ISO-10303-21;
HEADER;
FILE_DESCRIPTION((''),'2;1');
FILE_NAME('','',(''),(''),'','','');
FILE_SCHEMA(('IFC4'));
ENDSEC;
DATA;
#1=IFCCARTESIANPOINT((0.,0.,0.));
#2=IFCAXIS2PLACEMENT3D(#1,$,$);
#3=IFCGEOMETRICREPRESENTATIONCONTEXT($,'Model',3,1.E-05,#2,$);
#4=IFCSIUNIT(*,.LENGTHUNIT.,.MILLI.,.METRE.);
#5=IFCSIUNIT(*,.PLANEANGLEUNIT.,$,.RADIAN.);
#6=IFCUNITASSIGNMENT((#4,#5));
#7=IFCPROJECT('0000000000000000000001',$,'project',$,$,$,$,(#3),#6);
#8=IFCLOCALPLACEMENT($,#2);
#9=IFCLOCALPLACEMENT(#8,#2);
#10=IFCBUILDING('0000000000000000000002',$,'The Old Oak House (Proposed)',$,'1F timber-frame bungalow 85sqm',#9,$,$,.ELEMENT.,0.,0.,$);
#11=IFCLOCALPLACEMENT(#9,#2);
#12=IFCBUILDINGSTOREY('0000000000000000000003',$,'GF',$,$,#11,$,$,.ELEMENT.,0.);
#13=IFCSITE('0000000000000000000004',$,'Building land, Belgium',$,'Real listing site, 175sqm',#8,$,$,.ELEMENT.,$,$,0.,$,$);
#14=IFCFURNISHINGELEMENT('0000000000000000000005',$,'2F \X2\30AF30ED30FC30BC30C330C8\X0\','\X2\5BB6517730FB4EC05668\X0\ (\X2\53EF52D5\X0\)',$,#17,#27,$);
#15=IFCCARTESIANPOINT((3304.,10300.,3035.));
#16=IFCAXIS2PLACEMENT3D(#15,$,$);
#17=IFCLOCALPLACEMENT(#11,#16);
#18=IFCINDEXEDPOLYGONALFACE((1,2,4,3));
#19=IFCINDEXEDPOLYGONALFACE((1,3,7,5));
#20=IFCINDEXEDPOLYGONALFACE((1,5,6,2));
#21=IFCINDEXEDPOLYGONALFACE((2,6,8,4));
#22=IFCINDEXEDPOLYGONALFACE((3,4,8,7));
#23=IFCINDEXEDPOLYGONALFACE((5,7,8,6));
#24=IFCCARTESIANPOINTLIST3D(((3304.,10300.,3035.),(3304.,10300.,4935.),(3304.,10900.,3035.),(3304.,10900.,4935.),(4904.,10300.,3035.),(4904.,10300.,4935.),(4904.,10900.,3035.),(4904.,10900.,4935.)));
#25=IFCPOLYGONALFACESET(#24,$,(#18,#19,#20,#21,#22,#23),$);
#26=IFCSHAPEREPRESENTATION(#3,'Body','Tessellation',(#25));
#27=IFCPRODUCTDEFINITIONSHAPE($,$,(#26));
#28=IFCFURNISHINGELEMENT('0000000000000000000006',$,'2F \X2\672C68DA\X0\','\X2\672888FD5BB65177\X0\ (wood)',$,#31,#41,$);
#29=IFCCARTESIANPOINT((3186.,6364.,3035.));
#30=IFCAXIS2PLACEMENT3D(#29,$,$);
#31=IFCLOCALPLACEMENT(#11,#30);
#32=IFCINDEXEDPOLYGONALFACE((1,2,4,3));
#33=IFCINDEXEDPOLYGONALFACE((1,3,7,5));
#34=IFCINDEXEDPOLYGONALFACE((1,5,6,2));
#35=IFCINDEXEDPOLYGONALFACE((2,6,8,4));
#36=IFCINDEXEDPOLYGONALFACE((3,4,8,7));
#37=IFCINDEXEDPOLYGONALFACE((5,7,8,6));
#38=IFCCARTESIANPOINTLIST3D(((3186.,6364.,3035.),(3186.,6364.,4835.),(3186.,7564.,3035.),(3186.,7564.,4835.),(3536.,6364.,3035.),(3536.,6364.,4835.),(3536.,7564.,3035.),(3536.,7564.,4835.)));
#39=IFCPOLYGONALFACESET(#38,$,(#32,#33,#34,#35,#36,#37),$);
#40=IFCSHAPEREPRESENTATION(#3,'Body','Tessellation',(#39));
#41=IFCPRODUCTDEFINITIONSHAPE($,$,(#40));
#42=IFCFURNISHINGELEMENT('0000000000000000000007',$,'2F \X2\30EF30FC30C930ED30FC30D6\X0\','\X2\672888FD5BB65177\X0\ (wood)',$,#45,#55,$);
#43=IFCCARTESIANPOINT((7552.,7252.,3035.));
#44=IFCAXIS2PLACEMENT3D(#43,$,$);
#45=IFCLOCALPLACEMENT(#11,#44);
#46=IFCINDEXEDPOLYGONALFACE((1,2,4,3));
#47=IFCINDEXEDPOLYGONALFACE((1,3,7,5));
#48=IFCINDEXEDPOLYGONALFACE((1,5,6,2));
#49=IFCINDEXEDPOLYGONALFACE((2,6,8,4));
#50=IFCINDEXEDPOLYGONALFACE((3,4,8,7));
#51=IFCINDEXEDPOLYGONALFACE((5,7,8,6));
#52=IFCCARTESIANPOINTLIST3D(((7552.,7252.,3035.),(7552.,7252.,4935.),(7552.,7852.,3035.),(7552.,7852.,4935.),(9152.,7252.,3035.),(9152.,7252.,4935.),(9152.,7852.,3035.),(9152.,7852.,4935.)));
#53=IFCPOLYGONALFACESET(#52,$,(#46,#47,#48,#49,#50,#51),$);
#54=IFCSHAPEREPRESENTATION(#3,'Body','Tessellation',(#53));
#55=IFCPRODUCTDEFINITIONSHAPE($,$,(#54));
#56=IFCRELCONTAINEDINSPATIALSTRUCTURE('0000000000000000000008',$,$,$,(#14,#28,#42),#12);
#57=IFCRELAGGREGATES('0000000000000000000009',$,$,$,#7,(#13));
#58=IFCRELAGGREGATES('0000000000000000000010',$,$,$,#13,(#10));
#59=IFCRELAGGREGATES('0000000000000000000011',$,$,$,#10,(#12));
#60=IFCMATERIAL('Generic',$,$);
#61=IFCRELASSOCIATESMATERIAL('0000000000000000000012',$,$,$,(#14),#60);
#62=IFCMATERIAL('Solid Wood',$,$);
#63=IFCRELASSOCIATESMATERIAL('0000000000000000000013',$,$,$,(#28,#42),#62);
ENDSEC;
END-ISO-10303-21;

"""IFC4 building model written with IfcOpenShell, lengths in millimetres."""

from ifc_helpers import new_model, si_unit, frame, frame_2d, origin, place, context, project, spatial, rectangle, extrude, material, element, save


model = new_model("IFC4")

# Units and contexts
model_context = context("Model", 3, precision=1e-05, world=origin())
ifc_project = project(units=[si_unit("LENGTHUNIT", "METRE", prefix="MILLI"), si_unit("PLANEANGLEUNIT", "RADIAN")], contexts=[model_context])

# Site, building, storey
site_placement = place(None, origin())
site = spatial("IfcSite", under=ifc_project, at=site_placement, Name="Building land, Belgium", ObjectType="Real listing site, 175sqm", CompositionType="ELEMENT", RefElevation=0.0)
building_placement = place(site_placement, origin())
building = spatial("IfcBuilding", under=site, at=building_placement, Name="The Old Oak House (Proposed)", ObjectType="1F timber-frame bungalow 85sqm", CompositionType="ELEMENT", ElevationOfRefHeight=0.0, ElevationOfTerrain=0.0)
storey_placement = place(building_placement, origin())
storey = spatial("IfcBuildingStorey", under=building, at=storey_placement, Name="GF", CompositionType="ELEMENT", Elevation=0.0)

# Shared definitions
ifc_material_1 = material(Name="Solid Wood")

# Shared definitions
ifc_material_2 = material(Name="Generic")

# Furnishing elements
furnishing_1_placement = place(storey_placement, frame((3304.0, 10300.0, 3035.0)))
element("IfcFurnishingElement", 1, at=furnishing_1_placement, inside=storey, material=ifc_material_2, Name="2F クローゼット", Description="家具・什器 (可動)", context=model_context, shape_type="SweptSolid", body=[
    extrude(rectangle(XDim=1600.0, YDim=600.0, at=frame_2d((800.0, 300.0))), frame((3304.0, 10300.0, 3035.0)), (0.0, 0.0, 1.0), 1900.0),
])
furnishing_2_placement = place(storey_placement, frame((3186.0, 6364.0, 3035.0)))
element("IfcFurnishingElement", 2, at=furnishing_2_placement, inside=storey, material=ifc_material_1, Name="2F 本棚", Description="木製家具 (wood)", context=model_context, shape_type="SweptSolid", body=[
    extrude(rectangle(XDim=350.0, YDim=1200.0, at=frame_2d((175.0, 600.0))), frame((3186.0, 6364.0, 3035.0)), (0.0, 0.0, 1.0), 1800.0),
])
furnishing_3_placement = place(storey_placement, frame((7552.0, 7252.0, 3035.0)))
element("IfcFurnishingElement", 3, at=furnishing_3_placement, inside=storey, material=ifc_material_1, Name="2F ワードローブ", Description="木製家具 (wood)", context=model_context, shape_type="SweptSolid", body=[
    extrude(rectangle(XDim=1600.0, YDim=600.0, at=frame_2d((800.0, 300.0))), frame((7552.0, 7252.0, 3035.0)), (0.0, 0.0, 1.0), 1900.0),
])

save(model, "model.ifc")
